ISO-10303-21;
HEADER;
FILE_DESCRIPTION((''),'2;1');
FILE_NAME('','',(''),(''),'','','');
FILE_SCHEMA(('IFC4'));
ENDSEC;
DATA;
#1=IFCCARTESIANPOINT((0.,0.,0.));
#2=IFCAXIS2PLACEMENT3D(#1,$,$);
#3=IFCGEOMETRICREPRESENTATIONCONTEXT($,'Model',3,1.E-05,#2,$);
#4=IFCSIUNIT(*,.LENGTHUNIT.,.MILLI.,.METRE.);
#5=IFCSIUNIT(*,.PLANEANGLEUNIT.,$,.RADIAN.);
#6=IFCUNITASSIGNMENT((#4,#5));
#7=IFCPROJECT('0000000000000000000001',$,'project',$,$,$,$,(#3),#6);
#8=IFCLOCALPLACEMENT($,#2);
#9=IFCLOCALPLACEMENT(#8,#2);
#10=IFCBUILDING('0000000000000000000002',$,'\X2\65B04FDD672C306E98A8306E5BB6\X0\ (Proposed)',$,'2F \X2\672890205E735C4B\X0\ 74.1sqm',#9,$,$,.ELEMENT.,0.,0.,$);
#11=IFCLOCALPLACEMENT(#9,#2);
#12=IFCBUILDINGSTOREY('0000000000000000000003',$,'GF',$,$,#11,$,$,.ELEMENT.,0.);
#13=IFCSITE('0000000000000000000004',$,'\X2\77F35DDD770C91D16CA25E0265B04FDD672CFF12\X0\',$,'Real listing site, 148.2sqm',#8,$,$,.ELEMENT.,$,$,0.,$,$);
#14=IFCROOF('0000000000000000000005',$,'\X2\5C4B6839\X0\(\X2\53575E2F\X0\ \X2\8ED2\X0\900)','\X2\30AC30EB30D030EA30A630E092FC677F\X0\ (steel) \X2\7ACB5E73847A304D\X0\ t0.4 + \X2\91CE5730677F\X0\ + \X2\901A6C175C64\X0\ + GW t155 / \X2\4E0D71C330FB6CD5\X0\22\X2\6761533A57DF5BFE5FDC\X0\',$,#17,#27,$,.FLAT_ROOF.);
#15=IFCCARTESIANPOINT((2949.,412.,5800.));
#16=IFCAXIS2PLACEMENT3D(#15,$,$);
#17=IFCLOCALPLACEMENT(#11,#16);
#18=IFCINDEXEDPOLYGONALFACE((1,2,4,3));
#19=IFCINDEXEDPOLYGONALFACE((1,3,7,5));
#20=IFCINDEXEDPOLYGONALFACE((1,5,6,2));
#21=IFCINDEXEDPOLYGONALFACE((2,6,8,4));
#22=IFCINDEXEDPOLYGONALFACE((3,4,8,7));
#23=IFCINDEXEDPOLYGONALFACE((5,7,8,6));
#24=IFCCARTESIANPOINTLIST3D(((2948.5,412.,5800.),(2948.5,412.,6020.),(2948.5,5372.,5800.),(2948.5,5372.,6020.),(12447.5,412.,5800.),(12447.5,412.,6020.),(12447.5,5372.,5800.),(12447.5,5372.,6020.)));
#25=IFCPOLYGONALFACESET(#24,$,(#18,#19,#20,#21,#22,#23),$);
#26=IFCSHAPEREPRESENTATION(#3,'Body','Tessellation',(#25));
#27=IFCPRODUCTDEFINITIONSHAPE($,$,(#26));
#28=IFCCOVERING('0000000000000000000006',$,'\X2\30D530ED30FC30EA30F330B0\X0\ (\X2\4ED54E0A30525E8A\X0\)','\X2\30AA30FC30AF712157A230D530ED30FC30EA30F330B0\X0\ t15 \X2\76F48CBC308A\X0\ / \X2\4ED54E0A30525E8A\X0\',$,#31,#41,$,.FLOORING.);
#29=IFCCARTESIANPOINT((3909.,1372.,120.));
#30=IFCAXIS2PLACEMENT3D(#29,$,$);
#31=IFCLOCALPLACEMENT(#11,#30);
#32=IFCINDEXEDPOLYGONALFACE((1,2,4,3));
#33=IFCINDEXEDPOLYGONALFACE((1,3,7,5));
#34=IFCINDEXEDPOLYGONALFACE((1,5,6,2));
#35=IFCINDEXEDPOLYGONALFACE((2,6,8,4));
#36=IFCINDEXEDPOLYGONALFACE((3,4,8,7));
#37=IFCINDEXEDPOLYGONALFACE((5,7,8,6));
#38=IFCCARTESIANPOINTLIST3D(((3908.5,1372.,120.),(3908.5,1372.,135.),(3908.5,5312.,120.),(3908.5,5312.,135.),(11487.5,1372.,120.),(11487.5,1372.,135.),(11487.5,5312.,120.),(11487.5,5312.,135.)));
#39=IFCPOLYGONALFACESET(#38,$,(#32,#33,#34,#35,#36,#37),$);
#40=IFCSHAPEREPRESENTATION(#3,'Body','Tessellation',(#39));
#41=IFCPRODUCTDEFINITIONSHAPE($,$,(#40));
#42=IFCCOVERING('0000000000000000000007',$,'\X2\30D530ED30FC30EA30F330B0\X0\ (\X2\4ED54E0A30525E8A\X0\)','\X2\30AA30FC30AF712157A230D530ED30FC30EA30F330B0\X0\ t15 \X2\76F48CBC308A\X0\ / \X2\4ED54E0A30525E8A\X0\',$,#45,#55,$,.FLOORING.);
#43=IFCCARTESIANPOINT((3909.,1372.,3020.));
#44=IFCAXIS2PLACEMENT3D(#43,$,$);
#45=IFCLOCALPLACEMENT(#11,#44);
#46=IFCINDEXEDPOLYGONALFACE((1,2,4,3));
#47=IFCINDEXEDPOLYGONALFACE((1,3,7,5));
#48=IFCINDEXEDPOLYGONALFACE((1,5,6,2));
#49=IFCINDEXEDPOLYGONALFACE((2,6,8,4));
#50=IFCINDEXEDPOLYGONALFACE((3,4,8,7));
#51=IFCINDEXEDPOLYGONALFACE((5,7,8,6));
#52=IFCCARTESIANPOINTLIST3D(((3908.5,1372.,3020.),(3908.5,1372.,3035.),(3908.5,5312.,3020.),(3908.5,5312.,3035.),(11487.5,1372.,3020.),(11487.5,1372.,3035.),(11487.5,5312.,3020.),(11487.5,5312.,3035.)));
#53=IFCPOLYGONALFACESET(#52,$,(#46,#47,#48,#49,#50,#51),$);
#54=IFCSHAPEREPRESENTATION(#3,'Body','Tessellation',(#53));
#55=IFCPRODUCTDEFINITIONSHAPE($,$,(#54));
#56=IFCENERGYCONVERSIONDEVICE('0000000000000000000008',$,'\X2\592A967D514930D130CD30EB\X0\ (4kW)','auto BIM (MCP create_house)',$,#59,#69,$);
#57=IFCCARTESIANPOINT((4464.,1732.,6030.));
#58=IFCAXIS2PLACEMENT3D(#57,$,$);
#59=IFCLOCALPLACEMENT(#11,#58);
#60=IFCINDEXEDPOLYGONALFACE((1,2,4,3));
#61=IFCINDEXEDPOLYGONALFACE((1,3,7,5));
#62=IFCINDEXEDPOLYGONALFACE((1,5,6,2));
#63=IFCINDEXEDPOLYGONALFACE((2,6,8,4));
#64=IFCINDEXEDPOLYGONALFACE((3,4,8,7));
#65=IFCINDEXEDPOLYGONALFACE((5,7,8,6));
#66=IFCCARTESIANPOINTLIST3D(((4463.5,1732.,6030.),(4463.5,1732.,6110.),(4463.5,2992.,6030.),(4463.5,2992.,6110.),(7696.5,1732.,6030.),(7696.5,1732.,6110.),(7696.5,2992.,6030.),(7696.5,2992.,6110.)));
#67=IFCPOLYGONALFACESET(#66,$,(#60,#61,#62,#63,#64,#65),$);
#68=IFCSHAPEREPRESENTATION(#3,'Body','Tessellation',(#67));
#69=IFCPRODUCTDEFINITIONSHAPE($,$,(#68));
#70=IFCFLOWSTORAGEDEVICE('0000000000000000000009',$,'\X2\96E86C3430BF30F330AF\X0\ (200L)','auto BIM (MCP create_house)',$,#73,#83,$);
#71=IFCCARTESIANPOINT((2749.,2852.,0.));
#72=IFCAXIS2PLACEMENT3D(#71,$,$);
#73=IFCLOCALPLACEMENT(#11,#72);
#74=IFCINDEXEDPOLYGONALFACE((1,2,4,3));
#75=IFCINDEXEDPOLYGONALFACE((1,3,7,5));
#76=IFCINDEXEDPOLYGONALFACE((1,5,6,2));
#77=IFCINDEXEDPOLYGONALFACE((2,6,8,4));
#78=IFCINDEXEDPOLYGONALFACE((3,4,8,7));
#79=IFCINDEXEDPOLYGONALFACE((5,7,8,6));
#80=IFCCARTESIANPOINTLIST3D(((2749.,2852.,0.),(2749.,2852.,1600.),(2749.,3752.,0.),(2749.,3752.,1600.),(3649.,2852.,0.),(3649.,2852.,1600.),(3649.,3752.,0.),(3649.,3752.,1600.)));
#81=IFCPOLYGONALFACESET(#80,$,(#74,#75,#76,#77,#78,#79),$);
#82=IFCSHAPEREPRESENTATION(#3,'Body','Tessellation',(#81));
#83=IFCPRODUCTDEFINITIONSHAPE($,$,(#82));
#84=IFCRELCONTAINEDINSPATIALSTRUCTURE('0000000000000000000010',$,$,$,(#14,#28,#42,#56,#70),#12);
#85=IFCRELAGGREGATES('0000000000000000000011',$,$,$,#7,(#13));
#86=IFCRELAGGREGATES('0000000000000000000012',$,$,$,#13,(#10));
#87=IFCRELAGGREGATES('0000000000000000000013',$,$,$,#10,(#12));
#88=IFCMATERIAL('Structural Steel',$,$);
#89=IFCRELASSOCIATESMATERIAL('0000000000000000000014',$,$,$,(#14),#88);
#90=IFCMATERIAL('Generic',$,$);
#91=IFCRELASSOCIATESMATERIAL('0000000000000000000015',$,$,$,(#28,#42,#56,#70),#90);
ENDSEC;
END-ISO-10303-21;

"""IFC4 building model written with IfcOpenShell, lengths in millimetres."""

from ifc_helpers import new_model, si_unit, frame, frame_2d, origin, place, context, project, spatial, rectangle, extrude, material, element, save


model = new_model("IFC4")

# Units and contexts
model_context = context("Model", 3, precision=1e-05, world=origin())
ifc_project = project(units=[si_unit("LENGTHUNIT", "METRE", prefix="MILLI"), si_unit("PLANEANGLEUNIT", "RADIAN")], contexts=[model_context])

# Site, building, storey
site_placement = place(None, origin())
site = spatial("IfcSite", under=ifc_project, at=site_placement, Name="石川県金沢市新保本２", ObjectType="Real listing site, 148.2sqm", CompositionType="ELEMENT", RefElevation=0.0)
building_placement = place(site_placement, origin())
building = spatial("IfcBuilding", under=site, at=building_placement, Name="新保本の風の家 (Proposed)", ObjectType="2F 木造平屋 74.1sqm", CompositionType="ELEMENT", ElevationOfRefHeight=0.0, ElevationOfTerrain=0.0)
storey_placement = place(building_placement, origin())
storey = spatial("IfcBuildingStorey", under=building, at=storey_placement, Name="GF", CompositionType="ELEMENT", Elevation=0.0)

# Roof
ifc_material_1 = material(Name="Structural Steel")
for number, where, name in (
    (1, (2949.0, 412.0, 5800.0), "屋根(南帯 軒900)"),
):
    element("IfcRoof", number, at=place(storey_placement, frame(where)), inside=storey, material=ifc_material_1, Name=name, Description="ガルバリウム鋼板 (steel) 立平葺き t0.4 + 野地板 + 通気層 + GW t155 / 不燃・法22条区域対応", PredefinedType="FLAT_ROOF", context=model_context, shape_type="SweptSolid", body=[
        extrude(rectangle(XDim=9499.0, YDim=4960.0, at=frame_2d((4749.0, 2480.0))), frame((2949.0, 412.0, 5800.0)), (0.0, 0.0, 1.0), 220.0),
    ])

# Coverings
ifc_material_2 = material(Name="Generic")
covering_1_placement = place(storey_placement, frame((3909.0, 1372.0, 120.0)))
element("IfcCovering", 2, at=covering_1_placement, inside=storey, material=ifc_material_2, Name="フローリング (仕上げ床)", Description="オーク無垢フローリング t15 直貼り / 仕上げ床", PredefinedType="FLOORING", context=model_context, shape_type="SweptSolid", body=[
    extrude(rectangle(XDim=7579.0, YDim=3940.0, at=frame_2d((3789.0, 1970.0))), frame((3909.0, 1372.0, 120.0)), (0.0, 0.0, 1.0), 15.0),
])
covering_2_placement = place(storey_placement, frame((3909.0, 1372.0, 3020.0)))
element("IfcCovering", 3, at=covering_2_placement, inside=storey, material=ifc_material_2, Name="フローリング (仕上げ床)", Description="オーク無垢フローリング t15 直貼り / 仕上げ床", PredefinedType="FLOORING", context=model_context, shape_type="SweptSolid", body=[
    extrude(rectangle(XDim=7579.0, YDim=3940.0, at=frame_2d((3789.0, 1970.0))), frame((3909.0, 1372.0, 3020.0)), (0.0, 0.0, 1.0), 15.0),
])

# Energy conversion device
energy_conversion_device_placement = place(storey_placement, frame((4464.0, 1732.0, 6030.0)))
element("IfcEnergyConversionDevice", 4, at=energy_conversion_device_placement, inside=storey, material=ifc_material_2, Name="太陽光パネル (4kW)", Description="auto BIM (MCP create_house)", context=model_context, shape_type="SweptSolid", body=[
    extrude(rectangle(XDim=3233.0, YDim=1260.0, at=frame_2d((1616.0, 630.0))), frame((4464.0, 1732.0, 6030.0)), (0.0, 0.0, 1.0), 80.0),
])

# Flow storage device
flow_storage_device_placement = place(storey_placement, frame((2749.0, 2852.0, 0.0)))
element("IfcFlowStorageDevice", 5, at=flow_storage_device_placement, inside=storey, material=ifc_material_2, Name="雨水タンク (200L)", Description="auto BIM (MCP create_house)", context=model_context, shape_type="SweptSolid", body=[
    extrude(rectangle(XDim=900.0, YDim=900.0, at=frame_2d((450.0, 450.0))), frame((2749.0, 2852.0, 0.0)), (0.0, 0.0, 1.0), 1600.0),
])

save(model, "model.ifc")
